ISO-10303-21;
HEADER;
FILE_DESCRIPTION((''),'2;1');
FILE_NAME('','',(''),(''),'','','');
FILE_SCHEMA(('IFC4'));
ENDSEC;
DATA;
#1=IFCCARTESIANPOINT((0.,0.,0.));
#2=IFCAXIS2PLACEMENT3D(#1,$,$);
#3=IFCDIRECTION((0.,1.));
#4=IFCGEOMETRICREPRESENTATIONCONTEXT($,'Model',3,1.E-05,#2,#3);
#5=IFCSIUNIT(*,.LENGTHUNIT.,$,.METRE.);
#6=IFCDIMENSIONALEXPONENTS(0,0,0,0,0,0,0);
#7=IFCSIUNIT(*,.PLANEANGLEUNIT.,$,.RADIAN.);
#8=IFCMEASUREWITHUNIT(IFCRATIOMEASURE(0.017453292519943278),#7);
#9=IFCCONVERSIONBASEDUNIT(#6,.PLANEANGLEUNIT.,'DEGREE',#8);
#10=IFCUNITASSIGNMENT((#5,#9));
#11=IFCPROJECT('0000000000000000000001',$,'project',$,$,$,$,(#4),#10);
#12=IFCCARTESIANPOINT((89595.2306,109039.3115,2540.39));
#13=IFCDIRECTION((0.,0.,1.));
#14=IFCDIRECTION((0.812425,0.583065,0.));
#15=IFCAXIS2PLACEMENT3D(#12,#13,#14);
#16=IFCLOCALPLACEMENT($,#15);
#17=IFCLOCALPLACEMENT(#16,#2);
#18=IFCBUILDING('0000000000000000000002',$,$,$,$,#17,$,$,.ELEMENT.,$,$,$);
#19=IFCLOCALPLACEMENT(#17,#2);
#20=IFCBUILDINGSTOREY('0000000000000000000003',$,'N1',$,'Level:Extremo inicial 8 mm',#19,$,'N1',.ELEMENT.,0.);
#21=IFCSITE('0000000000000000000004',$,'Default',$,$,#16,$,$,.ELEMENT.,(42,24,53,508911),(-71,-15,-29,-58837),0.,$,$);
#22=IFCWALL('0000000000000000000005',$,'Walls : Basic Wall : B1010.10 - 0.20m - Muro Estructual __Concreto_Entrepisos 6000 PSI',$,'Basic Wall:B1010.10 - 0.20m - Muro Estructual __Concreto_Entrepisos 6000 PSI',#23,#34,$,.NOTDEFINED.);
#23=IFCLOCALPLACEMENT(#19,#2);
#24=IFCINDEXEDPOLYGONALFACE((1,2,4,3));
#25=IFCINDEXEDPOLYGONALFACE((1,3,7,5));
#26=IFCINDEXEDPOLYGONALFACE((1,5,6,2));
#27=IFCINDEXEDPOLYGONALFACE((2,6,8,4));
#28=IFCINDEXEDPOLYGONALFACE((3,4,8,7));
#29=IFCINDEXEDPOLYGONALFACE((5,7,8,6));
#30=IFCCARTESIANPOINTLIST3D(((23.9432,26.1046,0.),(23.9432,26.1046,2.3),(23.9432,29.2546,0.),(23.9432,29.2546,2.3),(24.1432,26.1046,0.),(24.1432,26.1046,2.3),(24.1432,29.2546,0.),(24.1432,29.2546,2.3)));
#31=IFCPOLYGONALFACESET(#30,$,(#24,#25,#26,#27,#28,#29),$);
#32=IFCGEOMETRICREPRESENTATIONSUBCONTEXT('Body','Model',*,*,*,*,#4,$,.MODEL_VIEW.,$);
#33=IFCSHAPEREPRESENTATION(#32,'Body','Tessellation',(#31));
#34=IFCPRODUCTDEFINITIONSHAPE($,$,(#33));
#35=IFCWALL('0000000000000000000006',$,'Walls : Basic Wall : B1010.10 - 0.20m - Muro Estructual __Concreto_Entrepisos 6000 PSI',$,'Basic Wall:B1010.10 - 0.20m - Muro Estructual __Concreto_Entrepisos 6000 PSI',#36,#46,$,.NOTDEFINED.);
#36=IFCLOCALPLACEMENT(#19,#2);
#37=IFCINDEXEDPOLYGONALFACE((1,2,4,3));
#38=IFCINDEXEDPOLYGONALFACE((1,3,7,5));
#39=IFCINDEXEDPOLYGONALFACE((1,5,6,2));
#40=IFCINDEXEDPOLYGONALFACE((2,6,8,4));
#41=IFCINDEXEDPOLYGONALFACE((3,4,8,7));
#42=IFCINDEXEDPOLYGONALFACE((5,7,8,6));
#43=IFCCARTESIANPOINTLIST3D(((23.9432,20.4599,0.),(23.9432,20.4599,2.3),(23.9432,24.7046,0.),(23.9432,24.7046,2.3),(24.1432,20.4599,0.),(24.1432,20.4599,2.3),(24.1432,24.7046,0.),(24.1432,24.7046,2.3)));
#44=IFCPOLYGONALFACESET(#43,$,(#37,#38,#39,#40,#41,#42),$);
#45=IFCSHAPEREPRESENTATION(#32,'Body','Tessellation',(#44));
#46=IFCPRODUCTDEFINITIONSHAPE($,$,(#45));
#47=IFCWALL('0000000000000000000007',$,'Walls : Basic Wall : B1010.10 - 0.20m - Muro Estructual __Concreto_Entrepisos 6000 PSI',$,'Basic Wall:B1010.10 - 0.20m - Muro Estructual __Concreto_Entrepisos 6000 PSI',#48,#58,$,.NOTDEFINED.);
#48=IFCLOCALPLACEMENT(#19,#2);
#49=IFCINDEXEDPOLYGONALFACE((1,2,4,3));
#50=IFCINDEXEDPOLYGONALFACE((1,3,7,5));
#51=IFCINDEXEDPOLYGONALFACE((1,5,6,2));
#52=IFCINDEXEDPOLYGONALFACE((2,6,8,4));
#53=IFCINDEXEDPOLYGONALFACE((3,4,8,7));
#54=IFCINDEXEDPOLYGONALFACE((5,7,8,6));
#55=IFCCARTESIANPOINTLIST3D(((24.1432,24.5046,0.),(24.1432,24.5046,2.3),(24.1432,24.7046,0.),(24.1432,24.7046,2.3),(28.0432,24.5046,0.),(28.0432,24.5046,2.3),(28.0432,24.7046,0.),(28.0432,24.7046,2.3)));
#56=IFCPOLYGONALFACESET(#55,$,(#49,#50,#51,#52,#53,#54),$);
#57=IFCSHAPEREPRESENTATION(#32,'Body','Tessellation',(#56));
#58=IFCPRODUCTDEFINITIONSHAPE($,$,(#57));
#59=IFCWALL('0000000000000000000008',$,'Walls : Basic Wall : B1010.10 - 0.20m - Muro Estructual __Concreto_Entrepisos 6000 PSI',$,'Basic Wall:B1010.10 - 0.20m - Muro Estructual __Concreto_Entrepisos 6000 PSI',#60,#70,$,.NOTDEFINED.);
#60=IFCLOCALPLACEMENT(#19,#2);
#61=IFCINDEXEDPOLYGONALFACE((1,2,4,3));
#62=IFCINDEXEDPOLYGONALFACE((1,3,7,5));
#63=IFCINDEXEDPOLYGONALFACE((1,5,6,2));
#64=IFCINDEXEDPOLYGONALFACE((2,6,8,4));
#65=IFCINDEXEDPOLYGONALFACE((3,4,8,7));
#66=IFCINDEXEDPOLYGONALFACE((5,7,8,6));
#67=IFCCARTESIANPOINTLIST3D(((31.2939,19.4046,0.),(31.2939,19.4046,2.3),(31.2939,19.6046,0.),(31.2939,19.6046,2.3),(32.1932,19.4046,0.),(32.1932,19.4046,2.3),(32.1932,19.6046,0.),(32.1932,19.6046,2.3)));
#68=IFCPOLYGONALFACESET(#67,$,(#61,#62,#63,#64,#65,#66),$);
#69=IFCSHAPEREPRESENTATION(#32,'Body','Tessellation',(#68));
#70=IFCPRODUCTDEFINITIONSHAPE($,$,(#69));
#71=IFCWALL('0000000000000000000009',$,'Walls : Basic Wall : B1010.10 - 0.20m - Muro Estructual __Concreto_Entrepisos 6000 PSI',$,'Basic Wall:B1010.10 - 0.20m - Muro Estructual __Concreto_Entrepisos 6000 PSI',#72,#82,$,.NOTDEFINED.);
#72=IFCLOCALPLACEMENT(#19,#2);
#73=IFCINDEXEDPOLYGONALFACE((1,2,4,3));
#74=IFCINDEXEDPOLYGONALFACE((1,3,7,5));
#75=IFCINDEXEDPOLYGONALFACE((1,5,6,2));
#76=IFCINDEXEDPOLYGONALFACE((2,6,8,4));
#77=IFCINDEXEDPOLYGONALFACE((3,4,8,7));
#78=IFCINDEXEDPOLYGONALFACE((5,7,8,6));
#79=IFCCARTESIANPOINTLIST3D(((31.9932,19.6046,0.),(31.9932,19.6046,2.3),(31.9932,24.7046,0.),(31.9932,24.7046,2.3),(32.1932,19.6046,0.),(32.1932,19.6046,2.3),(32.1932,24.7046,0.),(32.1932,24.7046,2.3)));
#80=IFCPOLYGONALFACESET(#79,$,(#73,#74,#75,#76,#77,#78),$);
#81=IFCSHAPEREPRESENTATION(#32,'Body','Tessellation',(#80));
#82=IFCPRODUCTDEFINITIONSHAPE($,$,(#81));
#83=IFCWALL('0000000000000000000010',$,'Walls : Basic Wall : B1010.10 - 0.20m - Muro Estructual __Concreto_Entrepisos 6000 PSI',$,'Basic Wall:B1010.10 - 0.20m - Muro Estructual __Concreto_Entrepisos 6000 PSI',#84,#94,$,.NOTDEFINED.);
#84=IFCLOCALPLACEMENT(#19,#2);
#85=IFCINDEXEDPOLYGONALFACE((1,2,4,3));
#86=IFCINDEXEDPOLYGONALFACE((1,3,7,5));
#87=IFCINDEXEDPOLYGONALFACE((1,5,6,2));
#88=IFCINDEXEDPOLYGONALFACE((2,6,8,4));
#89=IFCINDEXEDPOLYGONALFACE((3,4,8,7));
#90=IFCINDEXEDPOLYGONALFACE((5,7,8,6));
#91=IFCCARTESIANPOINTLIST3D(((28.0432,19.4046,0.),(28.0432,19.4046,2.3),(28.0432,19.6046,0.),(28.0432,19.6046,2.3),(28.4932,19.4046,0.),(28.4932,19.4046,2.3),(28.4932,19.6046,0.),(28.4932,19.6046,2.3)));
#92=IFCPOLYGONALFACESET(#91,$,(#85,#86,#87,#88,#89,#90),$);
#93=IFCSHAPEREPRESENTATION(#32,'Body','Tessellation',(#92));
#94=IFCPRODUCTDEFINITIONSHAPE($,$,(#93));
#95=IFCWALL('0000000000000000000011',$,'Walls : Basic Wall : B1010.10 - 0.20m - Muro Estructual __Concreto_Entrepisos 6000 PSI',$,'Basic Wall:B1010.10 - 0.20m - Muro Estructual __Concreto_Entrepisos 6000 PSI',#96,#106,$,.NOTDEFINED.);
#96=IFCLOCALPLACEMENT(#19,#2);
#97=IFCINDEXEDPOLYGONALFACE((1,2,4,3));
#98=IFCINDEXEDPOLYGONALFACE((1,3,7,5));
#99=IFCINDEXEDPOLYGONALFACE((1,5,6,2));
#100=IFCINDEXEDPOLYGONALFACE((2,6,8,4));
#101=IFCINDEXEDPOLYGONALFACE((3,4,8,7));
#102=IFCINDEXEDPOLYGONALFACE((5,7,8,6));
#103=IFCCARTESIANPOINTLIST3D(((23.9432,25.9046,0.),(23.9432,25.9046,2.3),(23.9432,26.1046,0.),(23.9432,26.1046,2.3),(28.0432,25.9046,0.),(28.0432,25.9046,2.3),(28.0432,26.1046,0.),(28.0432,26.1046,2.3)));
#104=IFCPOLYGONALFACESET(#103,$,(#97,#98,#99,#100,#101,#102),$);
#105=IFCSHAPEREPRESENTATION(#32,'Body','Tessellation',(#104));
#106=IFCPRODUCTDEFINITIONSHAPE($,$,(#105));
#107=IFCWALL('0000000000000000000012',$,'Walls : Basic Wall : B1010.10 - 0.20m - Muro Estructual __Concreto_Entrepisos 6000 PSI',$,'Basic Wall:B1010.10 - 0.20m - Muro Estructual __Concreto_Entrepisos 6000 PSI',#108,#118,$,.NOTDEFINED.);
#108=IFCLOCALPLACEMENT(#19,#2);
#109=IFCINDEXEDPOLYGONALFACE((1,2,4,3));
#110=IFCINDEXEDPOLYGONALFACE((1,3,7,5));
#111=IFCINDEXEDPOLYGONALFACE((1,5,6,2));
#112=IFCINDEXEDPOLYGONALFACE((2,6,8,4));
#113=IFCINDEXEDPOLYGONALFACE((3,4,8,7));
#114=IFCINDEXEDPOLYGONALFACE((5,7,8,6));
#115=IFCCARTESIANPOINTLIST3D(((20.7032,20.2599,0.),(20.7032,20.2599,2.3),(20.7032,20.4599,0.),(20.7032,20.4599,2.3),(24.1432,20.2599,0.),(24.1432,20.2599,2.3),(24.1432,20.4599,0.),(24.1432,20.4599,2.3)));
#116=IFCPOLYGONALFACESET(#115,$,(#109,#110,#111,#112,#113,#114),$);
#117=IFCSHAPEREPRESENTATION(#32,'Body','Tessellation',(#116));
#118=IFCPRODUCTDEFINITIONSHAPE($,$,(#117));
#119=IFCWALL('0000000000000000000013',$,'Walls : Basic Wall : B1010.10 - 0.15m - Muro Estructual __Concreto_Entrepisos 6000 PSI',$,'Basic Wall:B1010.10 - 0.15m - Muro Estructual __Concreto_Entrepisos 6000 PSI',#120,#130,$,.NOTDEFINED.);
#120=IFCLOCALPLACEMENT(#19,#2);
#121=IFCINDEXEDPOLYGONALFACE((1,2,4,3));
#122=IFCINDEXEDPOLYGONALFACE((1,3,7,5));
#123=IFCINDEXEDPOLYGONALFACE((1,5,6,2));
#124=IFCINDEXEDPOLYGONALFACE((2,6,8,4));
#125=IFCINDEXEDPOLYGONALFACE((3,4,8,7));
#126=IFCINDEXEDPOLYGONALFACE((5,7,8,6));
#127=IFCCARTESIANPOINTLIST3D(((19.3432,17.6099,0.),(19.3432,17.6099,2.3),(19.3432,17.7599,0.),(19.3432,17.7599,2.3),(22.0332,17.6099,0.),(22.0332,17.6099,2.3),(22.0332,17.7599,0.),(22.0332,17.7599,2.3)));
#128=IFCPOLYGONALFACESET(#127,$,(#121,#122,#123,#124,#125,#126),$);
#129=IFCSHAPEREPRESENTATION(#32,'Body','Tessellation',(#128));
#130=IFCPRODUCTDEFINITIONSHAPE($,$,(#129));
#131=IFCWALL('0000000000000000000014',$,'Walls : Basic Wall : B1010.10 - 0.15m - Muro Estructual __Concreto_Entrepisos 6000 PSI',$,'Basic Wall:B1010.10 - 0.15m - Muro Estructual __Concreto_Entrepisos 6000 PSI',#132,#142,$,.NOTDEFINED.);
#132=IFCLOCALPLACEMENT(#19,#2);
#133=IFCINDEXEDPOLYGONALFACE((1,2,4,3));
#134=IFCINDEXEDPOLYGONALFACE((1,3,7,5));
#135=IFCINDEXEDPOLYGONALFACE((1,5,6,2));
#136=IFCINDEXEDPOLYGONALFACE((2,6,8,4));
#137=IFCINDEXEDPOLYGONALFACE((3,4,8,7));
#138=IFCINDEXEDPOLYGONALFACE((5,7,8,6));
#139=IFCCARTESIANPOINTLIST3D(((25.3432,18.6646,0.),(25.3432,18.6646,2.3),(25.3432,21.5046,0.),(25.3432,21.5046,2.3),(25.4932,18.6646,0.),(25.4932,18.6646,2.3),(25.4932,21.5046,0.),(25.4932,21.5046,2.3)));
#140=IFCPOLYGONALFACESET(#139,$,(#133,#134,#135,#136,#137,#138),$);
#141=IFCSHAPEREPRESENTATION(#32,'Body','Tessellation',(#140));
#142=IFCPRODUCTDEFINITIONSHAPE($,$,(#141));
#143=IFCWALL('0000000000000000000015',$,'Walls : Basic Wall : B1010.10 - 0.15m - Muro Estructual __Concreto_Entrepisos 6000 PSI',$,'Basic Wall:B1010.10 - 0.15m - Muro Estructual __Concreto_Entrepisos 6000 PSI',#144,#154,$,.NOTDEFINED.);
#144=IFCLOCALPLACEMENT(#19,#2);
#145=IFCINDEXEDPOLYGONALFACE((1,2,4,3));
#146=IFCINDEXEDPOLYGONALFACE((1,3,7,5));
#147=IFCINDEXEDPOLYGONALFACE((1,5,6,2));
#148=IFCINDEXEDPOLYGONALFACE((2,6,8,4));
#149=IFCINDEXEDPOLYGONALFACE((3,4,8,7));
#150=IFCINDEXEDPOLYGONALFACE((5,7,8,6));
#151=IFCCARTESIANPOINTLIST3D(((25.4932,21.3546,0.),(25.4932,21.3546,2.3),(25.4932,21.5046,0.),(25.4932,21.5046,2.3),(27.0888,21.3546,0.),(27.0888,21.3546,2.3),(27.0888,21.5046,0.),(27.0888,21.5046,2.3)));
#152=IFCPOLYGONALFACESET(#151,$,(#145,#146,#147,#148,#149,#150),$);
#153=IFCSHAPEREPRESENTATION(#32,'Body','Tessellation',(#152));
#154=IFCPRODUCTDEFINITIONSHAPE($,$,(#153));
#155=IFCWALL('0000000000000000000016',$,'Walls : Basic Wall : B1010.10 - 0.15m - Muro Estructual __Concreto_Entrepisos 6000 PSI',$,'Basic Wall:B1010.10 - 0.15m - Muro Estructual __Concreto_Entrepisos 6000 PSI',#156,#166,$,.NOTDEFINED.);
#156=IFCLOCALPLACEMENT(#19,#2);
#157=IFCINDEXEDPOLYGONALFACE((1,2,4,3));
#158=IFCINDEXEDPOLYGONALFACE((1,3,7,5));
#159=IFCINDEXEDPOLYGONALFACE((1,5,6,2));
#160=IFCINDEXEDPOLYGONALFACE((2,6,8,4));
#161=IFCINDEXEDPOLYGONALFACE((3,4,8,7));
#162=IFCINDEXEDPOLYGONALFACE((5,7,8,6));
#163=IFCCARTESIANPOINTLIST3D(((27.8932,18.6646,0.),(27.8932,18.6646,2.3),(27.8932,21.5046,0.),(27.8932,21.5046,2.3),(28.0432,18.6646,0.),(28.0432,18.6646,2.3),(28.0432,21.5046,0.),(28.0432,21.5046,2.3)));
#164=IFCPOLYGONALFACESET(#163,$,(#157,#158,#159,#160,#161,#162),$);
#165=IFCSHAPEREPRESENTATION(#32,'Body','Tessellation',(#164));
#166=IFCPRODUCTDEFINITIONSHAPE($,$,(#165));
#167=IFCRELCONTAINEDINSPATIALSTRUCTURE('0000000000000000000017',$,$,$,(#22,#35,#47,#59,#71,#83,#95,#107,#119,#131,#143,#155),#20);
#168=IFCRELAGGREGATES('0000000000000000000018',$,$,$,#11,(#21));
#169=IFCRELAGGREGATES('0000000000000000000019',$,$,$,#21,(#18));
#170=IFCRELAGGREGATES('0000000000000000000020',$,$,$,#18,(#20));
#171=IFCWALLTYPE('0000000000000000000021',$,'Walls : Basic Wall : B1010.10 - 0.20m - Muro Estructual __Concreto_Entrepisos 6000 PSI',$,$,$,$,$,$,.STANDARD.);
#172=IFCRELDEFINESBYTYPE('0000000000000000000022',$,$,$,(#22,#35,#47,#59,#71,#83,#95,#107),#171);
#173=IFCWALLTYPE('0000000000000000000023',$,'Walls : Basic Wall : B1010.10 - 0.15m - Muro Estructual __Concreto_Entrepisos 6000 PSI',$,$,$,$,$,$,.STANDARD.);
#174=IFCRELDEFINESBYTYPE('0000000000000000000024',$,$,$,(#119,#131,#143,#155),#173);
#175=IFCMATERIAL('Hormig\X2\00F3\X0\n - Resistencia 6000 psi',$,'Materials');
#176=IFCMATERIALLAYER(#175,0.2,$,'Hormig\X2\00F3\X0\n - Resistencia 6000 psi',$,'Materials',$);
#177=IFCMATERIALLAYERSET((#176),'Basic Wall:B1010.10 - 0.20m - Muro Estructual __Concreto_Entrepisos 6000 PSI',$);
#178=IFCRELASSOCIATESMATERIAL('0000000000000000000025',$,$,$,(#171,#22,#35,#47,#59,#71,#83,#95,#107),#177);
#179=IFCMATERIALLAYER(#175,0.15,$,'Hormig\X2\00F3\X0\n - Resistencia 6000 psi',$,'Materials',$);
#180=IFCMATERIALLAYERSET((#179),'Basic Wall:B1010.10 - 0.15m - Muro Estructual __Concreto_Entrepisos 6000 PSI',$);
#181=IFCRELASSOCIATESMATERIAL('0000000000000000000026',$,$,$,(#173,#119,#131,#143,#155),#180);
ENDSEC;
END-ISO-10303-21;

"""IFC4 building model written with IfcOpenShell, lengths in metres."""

from ifc_helpers import new_model, entity, si_unit, converted_unit, direction, frame, frame_2d, origin, place, context, subcontext, project, spatial, rectangle, extrude, material, layer, layer_set, layer_usage, type_object, element, save


model = new_model("IFC4")

# Units and contexts
model_context = context("Model", 3, precision=1e-05, world=origin(), true_north=direction((0.0, 1.0)))
body_context = subcontext(model_context, "Body", "Model", "MODEL_VIEW")
ifc_project = project(units=[si_unit("LENGTHUNIT", "METRE"), converted_unit("PLANEANGLEUNIT", "DEGREE", entity("IfcRatioMeasure", 0.017453292519943278), si_unit("PLANEANGLEUNIT", "RADIAN"), dimensions=[0, 0, 0, 0, 0, 0, 0])], contexts=[model_context])

# Site, building, storey
site_placement = place(None, frame((89595.2306, 109039.3115, 2540.39), z_axis=(0.0, 0.0, 1.0), x_axis=(0.812425, 0.583065, 0.0)))
site = spatial("IfcSite", under=ifc_project, at=site_placement, Name="Default", CompositionType="ELEMENT", RefLatitude=(42, 24, 53, 508911), RefLongitude=(-71, -15, -29, -58837), RefElevation=0.0)
building_placement = place(site_placement, origin())
building = spatial("IfcBuilding", under=site, at=building_placement, CompositionType="ELEMENT")
storey_placement = place(building_placement, origin())
storey = spatial("IfcBuildingStorey", under=building, at=storey_placement, Name="N1", ObjectType="Level:Extremo inicial 8 mm", LongName="N1", CompositionType="ELEMENT", Elevation=0.0)

# Walls
ifc_material_1 = material(Name="Hormigón - Resistencia 6000 psi", Category="Materials")
ifc_layer_1 = layer(ifc_material_1, 0.2, Name="Hormigón - Resistencia 6000 psi", Category="Materials")
ifc_layer_set_1 = layer_set([ifc_layer_1], Name="Basic Wall:B1010.10 - 0.20m - Muro Estructual __Concreto_Entrepisos 6000 PSI")
ifc_layer_usage_1 = layer_usage(ifc_layer_set_1, "AXIS2", "NEGATIVE", 0.1)
wall_type_1 = type_object("IfcWallType", Name="Walls : Basic Wall : B1010.10 - 0.20m - Muro Estructual __Concreto_Entrepisos 6000 PSI", PredefinedType="STANDARD", material=ifc_layer_set_1)
wall_1_placement = place(storey_placement, frame((24.0432, 26.1046, 0.0), z_axis=(0.0, 0.0, 1.0), x_axis=(0.0, 1.0, 0.0)))
element("IfcWall", 1, at=wall_1_placement, inside=storey, type_object=wall_type_1, material=ifc_layer_usage_1, Name="Walls : Basic Wall : B1010.10 - 0.20m - Muro Estructual __Concreto_Entrepisos 6000 PSI", ObjectType="Basic Wall:B1010.10 - 0.20m - Muro Estructual __Concreto_Entrepisos 6000 PSI", PredefinedType="NOTDEFINED", context=body_context, shape_type="SweptSolid", body=[
    extrude(rectangle(XDim=3.15, YDim=0.2, at=frame_2d((1.575, 0.0), x_axis=(-1.0, 0.0))), origin(), (0.0, 0.0, 1.0), 2.3),
])
ifc_layer_usage_2 = layer_usage(ifc_layer_set_1, "AXIS2", "NEGATIVE", 0.1)
wall_2_placement = place(storey_placement, frame((24.0432, 20.4599, 0.0), z_axis=(0.0, 0.0, 1.0), x_axis=(0.0, 1.0, 0.0)))
element("IfcWall", 2, at=wall_2_placement, inside=storey, type_object=wall_type_1, material=ifc_layer_usage_2, Name="Walls : Basic Wall : B1010.10 - 0.20m - Muro Estructual __Concreto_Entrepisos 6000 PSI", ObjectType="Basic Wall:B1010.10 - 0.20m - Muro Estructual __Concreto_Entrepisos 6000 PSI", PredefinedType="NOTDEFINED", context=body_context, shape_type="SweptSolid", body=[
    extrude(rectangle(XDim=4.2447, YDim=0.2, at=frame_2d((2.1224, 0.0), x_axis=(-1.0, 0.0))), origin(), (0.0, 0.0, 1.0), 2.3),
])
ifc_layer_usage_3 = layer_usage(ifc_layer_set_1, "AXIS2", "NEGATIVE", 0.1)
wall_3_placement = place(storey_placement, frame((24.1432, 24.6046, 0.0)))
element("IfcWall", 3, at=wall_3_placement, inside=storey, type_object=wall_type_1, material=ifc_layer_usage_3, Name="Walls : Basic Wall : B1010.10 - 0.20m - Muro Estructual __Concreto_Entrepisos 6000 PSI", ObjectType="Basic Wall:B1010.10 - 0.20m - Muro Estructual __Concreto_Entrepisos 6000 PSI", PredefinedType="NOTDEFINED", context=body_context, shape_type="SweptSolid", body=[
    extrude(rectangle(XDim=3.9, YDim=0.2, at=frame_2d((1.95, 0.0), x_axis=(-1.0, 0.0))), origin(), (0.0, 0.0, 1.0), 2.3),
])
ifc_layer_usage_4 = layer_usage(ifc_layer_set_1, "AXIS2", "NEGATIVE", 0.1)
wall_4_placement = place(storey_placement, frame((31.2939, 19.5046, 0.0)))
element("IfcWall", 4, at=wall_4_placement, inside=storey, type_object=wall_type_1, material=ifc_layer_usage_4, Name="Walls : Basic Wall : B1010.10 - 0.20m - Muro Estructual __Concreto_Entrepisos 6000 PSI", ObjectType="Basic Wall:B1010.10 - 0.20m - Muro Estructual __Concreto_Entrepisos 6000 PSI", PredefinedType="NOTDEFINED", context=body_context, shape_type="SweptSolid", body=[
    extrude(rectangle(XDim=0.8993, YDim=0.2, at=frame_2d((0.4497, 0.0), x_axis=(-1.0, 0.0))), origin(), (0.0, 0.0, 1.0), 2.3),
])
ifc_layer_usage_5 = layer_usage(ifc_layer_set_1, "AXIS2", "NEGATIVE", 0.1)
wall_5_placement = place(storey_placement, frame((32.0932, 19.6046, 0.0), z_axis=(0.0, 0.0, 1.0), x_axis=(0.0, 1.0, 0.0)))
element("IfcWall", 5, at=wall_5_placement, inside=storey, type_object=wall_type_1, material=ifc_layer_usage_5, Name="Walls : Basic Wall : B1010.10 - 0.20m - Muro Estructual __Concreto_Entrepisos 6000 PSI", ObjectType="Basic Wall:B1010.10 - 0.20m - Muro Estructual __Concreto_Entrepisos 6000 PSI", PredefinedType="NOTDEFINED", context=body_context, shape_type="SweptSolid", body=[
    extrude(rectangle(XDim=5.1, YDim=0.2, at=frame_2d((2.55, 0.0), x_axis=(-1.0, 0.0))), origin(), (0.0, 0.0, 1.0), 2.3),
])
ifc_layer_usage_6 = layer_usage(ifc_layer_set_1, "AXIS2", "NEGATIVE", 0.1)
wall_6_placement = place(storey_placement, frame((28.4932, 19.5046, 0.0), z_axis=(0.0, 0.0, 1.0), x_axis=(-1.0, 0.0, 0.0)))
element("IfcWall", 6, at=wall_6_placement, inside=storey, type_object=wall_type_1, material=ifc_layer_usage_6, Name="Walls : Basic Wall : B1010.10 - 0.20m - Muro Estructual __Concreto_Entrepisos 6000 PSI", ObjectType="Basic Wall:B1010.10 - 0.20m - Muro Estructual __Concreto_Entrepisos 6000 PSI", PredefinedType="NOTDEFINED", context=body_context, shape_type="SweptSolid", body=[
    extrude(rectangle(XDim=0.45, YDim=0.2, at=frame_2d((0.225, 0.0), x_axis=(-1.0, 0.0))), origin(), (0.0, 0.0, 1.0), 2.3),
])
ifc_layer_usage_7 = layer_usage(ifc_layer_set_1, "AXIS2", "NEGATIVE", 0.1)
wall_7_placement = place(storey_placement, frame((23.9432, 26.0046, 0.0)))
element("IfcWall", 7, at=wall_7_placement, inside=storey, type_object=wall_type_1, material=ifc_layer_usage_7, Name="Walls : Basic Wall : B1010.10 - 0.20m - Muro Estructual __Concreto_Entrepisos 6000 PSI", ObjectType="Basic Wall:B1010.10 - 0.20m - Muro Estructual __Concreto_Entrepisos 6000 PSI", PredefinedType="NOTDEFINED", context=body_context, shape_type="SweptSolid", body=[
    extrude(rectangle(XDim=4.1, YDim=0.2, at=frame_2d((2.05, 0.0), x_axis=(-1.0, 0.0))), origin(), (0.0, 0.0, 1.0), 2.3),
])
ifc_layer_usage_8 = layer_usage(ifc_layer_set_1, "AXIS2", "NEGATIVE", 0.1)
wall_8_placement = place(storey_placement, frame((20.7032, 20.3599, 0.0)))
element("IfcWall", 8, at=wall_8_placement, inside=storey, type_object=wall_type_1, material=ifc_layer_usage_8, Name="Walls : Basic Wall : B1010.10 - 0.20m - Muro Estructual __Concreto_Entrepisos 6000 PSI", ObjectType="Basic Wall:B1010.10 - 0.20m - Muro Estructual __Concreto_Entrepisos 6000 PSI", PredefinedType="NOTDEFINED", context=body_context, shape_type="SweptSolid", body=[
    extrude(rectangle(XDim=3.44, YDim=0.2, at=frame_2d((1.72, 0.0), x_axis=(-1.0, 0.0))), origin(), (0.0, 0.0, 1.0), 2.3),
])
ifc_layer_2 = layer(ifc_material_1, 0.15, Name="Hormigón - Resistencia 6000 psi", Category="Materials")
ifc_layer_set_2 = layer_set([ifc_layer_2], Name="Basic Wall:B1010.10 - 0.15m - Muro Estructual __Concreto_Entrepisos 6000 PSI")
ifc_layer_usage_9 = layer_usage(ifc_layer_set_2, "AXIS2", "NEGATIVE", 0.075)
wall_type_2 = type_object("IfcWallType", Name="Walls : Basic Wall : B1010.10 - 0.15m - Muro Estructual __Concreto_Entrepisos 6000 PSI", PredefinedType="STANDARD", material=ifc_layer_set_2)
wall_9_placement = place(storey_placement, frame((22.0332, 17.6849, 0.0), z_axis=(0.0, 0.0, 1.0), x_axis=(-1.0, 0.0, 0.0)))
element("IfcWall", 9, at=wall_9_placement, inside=storey, type_object=wall_type_2, material=ifc_layer_usage_9, Name="Walls : Basic Wall : B1010.10 - 0.15m - Muro Estructual __Concreto_Entrepisos 6000 PSI", ObjectType="Basic Wall:B1010.10 - 0.15m - Muro Estructual __Concreto_Entrepisos 6000 PSI", PredefinedType="NOTDEFINED", context=body_context, shape_type="SweptSolid", body=[
    extrude(rectangle(XDim=2.69, YDim=0.15, at=frame_2d((1.345, 0.0), x_axis=(-1.0, 0.0))), origin(), (0.0, 0.0, 1.0), 2.3),
])
ifc_layer_usage_10 = layer_usage(ifc_layer_set_2, "AXIS2", "NEGATIVE", 0.075)
wall_10_placement = place(storey_placement, frame((25.4182, 18.6646, 0.0), z_axis=(0.0, 0.0, 1.0), x_axis=(0.0, 1.0, 0.0)))
element("IfcWall", 10, at=wall_10_placement, inside=storey, type_object=wall_type_2, material=ifc_layer_usage_10, Name="Walls : Basic Wall : B1010.10 - 0.15m - Muro Estructual __Concreto_Entrepisos 6000 PSI", ObjectType="Basic Wall:B1010.10 - 0.15m - Muro Estructual __Concreto_Entrepisos 6000 PSI", PredefinedType="NOTDEFINED", context=body_context, shape_type="SweptSolid", body=[
    extrude(rectangle(XDim=2.84, YDim=0.15, at=frame_2d((1.42, 0.0), x_axis=(-1.0, 0.0))), origin(), (0.0, 0.0, 1.0), 2.3),
])
ifc_layer_usage_11 = layer_usage(ifc_layer_set_2, "AXIS2", "NEGATIVE", 0.075)
wall_11_placement = place(storey_placement, frame((27.0888, 21.4296, 0.0), z_axis=(0.0, 0.0, 1.0), x_axis=(-1.0, 0.0, 0.0)))
element("IfcWall", 11, at=wall_11_placement, inside=storey, type_object=wall_type_2, material=ifc_layer_usage_11, Name="Walls : Basic Wall : B1010.10 - 0.15m - Muro Estructual __Concreto_Entrepisos 6000 PSI", ObjectType="Basic Wall:B1010.10 - 0.15m - Muro Estructual __Concreto_Entrepisos 6000 PSI", PredefinedType="NOTDEFINED", context=body_context, shape_type="SweptSolid", body=[
    extrude(rectangle(XDim=1.5955, YDim=0.15, at=frame_2d((0.7978, 0.0), x_axis=(-1.0, 0.0))), origin(), (0.0, 0.0, 1.0), 2.3),
])
ifc_layer_usage_12 = layer_usage(ifc_layer_set_2, "AXIS2", "NEGATIVE", 0.075)
wall_12_placement = place(storey_placement, frame((27.9682, 18.6646, 0.0), z_axis=(0.0, 0.0, 1.0), x_axis=(0.0, 1.0, 0.0)))
element("IfcWall", 12, at=wall_12_placement, inside=storey, type_object=wall_type_2, material=ifc_layer_usage_12, Name="Walls : Basic Wall : B1010.10 - 0.15m - Muro Estructual __Concreto_Entrepisos 6000 PSI", ObjectType="Basic Wall:B1010.10 - 0.15m - Muro Estructual __Concreto_Entrepisos 6000 PSI", PredefinedType="NOTDEFINED", context=body_context, shape_type="SweptSolid", body=[
    extrude(rectangle(XDim=2.84, YDim=0.15, at=frame_2d((1.42, 0.0), x_axis=(-1.0, 0.0))), origin(), (0.0, 0.0, 1.0), 2.3),
])

save(model, "model.ifc")
